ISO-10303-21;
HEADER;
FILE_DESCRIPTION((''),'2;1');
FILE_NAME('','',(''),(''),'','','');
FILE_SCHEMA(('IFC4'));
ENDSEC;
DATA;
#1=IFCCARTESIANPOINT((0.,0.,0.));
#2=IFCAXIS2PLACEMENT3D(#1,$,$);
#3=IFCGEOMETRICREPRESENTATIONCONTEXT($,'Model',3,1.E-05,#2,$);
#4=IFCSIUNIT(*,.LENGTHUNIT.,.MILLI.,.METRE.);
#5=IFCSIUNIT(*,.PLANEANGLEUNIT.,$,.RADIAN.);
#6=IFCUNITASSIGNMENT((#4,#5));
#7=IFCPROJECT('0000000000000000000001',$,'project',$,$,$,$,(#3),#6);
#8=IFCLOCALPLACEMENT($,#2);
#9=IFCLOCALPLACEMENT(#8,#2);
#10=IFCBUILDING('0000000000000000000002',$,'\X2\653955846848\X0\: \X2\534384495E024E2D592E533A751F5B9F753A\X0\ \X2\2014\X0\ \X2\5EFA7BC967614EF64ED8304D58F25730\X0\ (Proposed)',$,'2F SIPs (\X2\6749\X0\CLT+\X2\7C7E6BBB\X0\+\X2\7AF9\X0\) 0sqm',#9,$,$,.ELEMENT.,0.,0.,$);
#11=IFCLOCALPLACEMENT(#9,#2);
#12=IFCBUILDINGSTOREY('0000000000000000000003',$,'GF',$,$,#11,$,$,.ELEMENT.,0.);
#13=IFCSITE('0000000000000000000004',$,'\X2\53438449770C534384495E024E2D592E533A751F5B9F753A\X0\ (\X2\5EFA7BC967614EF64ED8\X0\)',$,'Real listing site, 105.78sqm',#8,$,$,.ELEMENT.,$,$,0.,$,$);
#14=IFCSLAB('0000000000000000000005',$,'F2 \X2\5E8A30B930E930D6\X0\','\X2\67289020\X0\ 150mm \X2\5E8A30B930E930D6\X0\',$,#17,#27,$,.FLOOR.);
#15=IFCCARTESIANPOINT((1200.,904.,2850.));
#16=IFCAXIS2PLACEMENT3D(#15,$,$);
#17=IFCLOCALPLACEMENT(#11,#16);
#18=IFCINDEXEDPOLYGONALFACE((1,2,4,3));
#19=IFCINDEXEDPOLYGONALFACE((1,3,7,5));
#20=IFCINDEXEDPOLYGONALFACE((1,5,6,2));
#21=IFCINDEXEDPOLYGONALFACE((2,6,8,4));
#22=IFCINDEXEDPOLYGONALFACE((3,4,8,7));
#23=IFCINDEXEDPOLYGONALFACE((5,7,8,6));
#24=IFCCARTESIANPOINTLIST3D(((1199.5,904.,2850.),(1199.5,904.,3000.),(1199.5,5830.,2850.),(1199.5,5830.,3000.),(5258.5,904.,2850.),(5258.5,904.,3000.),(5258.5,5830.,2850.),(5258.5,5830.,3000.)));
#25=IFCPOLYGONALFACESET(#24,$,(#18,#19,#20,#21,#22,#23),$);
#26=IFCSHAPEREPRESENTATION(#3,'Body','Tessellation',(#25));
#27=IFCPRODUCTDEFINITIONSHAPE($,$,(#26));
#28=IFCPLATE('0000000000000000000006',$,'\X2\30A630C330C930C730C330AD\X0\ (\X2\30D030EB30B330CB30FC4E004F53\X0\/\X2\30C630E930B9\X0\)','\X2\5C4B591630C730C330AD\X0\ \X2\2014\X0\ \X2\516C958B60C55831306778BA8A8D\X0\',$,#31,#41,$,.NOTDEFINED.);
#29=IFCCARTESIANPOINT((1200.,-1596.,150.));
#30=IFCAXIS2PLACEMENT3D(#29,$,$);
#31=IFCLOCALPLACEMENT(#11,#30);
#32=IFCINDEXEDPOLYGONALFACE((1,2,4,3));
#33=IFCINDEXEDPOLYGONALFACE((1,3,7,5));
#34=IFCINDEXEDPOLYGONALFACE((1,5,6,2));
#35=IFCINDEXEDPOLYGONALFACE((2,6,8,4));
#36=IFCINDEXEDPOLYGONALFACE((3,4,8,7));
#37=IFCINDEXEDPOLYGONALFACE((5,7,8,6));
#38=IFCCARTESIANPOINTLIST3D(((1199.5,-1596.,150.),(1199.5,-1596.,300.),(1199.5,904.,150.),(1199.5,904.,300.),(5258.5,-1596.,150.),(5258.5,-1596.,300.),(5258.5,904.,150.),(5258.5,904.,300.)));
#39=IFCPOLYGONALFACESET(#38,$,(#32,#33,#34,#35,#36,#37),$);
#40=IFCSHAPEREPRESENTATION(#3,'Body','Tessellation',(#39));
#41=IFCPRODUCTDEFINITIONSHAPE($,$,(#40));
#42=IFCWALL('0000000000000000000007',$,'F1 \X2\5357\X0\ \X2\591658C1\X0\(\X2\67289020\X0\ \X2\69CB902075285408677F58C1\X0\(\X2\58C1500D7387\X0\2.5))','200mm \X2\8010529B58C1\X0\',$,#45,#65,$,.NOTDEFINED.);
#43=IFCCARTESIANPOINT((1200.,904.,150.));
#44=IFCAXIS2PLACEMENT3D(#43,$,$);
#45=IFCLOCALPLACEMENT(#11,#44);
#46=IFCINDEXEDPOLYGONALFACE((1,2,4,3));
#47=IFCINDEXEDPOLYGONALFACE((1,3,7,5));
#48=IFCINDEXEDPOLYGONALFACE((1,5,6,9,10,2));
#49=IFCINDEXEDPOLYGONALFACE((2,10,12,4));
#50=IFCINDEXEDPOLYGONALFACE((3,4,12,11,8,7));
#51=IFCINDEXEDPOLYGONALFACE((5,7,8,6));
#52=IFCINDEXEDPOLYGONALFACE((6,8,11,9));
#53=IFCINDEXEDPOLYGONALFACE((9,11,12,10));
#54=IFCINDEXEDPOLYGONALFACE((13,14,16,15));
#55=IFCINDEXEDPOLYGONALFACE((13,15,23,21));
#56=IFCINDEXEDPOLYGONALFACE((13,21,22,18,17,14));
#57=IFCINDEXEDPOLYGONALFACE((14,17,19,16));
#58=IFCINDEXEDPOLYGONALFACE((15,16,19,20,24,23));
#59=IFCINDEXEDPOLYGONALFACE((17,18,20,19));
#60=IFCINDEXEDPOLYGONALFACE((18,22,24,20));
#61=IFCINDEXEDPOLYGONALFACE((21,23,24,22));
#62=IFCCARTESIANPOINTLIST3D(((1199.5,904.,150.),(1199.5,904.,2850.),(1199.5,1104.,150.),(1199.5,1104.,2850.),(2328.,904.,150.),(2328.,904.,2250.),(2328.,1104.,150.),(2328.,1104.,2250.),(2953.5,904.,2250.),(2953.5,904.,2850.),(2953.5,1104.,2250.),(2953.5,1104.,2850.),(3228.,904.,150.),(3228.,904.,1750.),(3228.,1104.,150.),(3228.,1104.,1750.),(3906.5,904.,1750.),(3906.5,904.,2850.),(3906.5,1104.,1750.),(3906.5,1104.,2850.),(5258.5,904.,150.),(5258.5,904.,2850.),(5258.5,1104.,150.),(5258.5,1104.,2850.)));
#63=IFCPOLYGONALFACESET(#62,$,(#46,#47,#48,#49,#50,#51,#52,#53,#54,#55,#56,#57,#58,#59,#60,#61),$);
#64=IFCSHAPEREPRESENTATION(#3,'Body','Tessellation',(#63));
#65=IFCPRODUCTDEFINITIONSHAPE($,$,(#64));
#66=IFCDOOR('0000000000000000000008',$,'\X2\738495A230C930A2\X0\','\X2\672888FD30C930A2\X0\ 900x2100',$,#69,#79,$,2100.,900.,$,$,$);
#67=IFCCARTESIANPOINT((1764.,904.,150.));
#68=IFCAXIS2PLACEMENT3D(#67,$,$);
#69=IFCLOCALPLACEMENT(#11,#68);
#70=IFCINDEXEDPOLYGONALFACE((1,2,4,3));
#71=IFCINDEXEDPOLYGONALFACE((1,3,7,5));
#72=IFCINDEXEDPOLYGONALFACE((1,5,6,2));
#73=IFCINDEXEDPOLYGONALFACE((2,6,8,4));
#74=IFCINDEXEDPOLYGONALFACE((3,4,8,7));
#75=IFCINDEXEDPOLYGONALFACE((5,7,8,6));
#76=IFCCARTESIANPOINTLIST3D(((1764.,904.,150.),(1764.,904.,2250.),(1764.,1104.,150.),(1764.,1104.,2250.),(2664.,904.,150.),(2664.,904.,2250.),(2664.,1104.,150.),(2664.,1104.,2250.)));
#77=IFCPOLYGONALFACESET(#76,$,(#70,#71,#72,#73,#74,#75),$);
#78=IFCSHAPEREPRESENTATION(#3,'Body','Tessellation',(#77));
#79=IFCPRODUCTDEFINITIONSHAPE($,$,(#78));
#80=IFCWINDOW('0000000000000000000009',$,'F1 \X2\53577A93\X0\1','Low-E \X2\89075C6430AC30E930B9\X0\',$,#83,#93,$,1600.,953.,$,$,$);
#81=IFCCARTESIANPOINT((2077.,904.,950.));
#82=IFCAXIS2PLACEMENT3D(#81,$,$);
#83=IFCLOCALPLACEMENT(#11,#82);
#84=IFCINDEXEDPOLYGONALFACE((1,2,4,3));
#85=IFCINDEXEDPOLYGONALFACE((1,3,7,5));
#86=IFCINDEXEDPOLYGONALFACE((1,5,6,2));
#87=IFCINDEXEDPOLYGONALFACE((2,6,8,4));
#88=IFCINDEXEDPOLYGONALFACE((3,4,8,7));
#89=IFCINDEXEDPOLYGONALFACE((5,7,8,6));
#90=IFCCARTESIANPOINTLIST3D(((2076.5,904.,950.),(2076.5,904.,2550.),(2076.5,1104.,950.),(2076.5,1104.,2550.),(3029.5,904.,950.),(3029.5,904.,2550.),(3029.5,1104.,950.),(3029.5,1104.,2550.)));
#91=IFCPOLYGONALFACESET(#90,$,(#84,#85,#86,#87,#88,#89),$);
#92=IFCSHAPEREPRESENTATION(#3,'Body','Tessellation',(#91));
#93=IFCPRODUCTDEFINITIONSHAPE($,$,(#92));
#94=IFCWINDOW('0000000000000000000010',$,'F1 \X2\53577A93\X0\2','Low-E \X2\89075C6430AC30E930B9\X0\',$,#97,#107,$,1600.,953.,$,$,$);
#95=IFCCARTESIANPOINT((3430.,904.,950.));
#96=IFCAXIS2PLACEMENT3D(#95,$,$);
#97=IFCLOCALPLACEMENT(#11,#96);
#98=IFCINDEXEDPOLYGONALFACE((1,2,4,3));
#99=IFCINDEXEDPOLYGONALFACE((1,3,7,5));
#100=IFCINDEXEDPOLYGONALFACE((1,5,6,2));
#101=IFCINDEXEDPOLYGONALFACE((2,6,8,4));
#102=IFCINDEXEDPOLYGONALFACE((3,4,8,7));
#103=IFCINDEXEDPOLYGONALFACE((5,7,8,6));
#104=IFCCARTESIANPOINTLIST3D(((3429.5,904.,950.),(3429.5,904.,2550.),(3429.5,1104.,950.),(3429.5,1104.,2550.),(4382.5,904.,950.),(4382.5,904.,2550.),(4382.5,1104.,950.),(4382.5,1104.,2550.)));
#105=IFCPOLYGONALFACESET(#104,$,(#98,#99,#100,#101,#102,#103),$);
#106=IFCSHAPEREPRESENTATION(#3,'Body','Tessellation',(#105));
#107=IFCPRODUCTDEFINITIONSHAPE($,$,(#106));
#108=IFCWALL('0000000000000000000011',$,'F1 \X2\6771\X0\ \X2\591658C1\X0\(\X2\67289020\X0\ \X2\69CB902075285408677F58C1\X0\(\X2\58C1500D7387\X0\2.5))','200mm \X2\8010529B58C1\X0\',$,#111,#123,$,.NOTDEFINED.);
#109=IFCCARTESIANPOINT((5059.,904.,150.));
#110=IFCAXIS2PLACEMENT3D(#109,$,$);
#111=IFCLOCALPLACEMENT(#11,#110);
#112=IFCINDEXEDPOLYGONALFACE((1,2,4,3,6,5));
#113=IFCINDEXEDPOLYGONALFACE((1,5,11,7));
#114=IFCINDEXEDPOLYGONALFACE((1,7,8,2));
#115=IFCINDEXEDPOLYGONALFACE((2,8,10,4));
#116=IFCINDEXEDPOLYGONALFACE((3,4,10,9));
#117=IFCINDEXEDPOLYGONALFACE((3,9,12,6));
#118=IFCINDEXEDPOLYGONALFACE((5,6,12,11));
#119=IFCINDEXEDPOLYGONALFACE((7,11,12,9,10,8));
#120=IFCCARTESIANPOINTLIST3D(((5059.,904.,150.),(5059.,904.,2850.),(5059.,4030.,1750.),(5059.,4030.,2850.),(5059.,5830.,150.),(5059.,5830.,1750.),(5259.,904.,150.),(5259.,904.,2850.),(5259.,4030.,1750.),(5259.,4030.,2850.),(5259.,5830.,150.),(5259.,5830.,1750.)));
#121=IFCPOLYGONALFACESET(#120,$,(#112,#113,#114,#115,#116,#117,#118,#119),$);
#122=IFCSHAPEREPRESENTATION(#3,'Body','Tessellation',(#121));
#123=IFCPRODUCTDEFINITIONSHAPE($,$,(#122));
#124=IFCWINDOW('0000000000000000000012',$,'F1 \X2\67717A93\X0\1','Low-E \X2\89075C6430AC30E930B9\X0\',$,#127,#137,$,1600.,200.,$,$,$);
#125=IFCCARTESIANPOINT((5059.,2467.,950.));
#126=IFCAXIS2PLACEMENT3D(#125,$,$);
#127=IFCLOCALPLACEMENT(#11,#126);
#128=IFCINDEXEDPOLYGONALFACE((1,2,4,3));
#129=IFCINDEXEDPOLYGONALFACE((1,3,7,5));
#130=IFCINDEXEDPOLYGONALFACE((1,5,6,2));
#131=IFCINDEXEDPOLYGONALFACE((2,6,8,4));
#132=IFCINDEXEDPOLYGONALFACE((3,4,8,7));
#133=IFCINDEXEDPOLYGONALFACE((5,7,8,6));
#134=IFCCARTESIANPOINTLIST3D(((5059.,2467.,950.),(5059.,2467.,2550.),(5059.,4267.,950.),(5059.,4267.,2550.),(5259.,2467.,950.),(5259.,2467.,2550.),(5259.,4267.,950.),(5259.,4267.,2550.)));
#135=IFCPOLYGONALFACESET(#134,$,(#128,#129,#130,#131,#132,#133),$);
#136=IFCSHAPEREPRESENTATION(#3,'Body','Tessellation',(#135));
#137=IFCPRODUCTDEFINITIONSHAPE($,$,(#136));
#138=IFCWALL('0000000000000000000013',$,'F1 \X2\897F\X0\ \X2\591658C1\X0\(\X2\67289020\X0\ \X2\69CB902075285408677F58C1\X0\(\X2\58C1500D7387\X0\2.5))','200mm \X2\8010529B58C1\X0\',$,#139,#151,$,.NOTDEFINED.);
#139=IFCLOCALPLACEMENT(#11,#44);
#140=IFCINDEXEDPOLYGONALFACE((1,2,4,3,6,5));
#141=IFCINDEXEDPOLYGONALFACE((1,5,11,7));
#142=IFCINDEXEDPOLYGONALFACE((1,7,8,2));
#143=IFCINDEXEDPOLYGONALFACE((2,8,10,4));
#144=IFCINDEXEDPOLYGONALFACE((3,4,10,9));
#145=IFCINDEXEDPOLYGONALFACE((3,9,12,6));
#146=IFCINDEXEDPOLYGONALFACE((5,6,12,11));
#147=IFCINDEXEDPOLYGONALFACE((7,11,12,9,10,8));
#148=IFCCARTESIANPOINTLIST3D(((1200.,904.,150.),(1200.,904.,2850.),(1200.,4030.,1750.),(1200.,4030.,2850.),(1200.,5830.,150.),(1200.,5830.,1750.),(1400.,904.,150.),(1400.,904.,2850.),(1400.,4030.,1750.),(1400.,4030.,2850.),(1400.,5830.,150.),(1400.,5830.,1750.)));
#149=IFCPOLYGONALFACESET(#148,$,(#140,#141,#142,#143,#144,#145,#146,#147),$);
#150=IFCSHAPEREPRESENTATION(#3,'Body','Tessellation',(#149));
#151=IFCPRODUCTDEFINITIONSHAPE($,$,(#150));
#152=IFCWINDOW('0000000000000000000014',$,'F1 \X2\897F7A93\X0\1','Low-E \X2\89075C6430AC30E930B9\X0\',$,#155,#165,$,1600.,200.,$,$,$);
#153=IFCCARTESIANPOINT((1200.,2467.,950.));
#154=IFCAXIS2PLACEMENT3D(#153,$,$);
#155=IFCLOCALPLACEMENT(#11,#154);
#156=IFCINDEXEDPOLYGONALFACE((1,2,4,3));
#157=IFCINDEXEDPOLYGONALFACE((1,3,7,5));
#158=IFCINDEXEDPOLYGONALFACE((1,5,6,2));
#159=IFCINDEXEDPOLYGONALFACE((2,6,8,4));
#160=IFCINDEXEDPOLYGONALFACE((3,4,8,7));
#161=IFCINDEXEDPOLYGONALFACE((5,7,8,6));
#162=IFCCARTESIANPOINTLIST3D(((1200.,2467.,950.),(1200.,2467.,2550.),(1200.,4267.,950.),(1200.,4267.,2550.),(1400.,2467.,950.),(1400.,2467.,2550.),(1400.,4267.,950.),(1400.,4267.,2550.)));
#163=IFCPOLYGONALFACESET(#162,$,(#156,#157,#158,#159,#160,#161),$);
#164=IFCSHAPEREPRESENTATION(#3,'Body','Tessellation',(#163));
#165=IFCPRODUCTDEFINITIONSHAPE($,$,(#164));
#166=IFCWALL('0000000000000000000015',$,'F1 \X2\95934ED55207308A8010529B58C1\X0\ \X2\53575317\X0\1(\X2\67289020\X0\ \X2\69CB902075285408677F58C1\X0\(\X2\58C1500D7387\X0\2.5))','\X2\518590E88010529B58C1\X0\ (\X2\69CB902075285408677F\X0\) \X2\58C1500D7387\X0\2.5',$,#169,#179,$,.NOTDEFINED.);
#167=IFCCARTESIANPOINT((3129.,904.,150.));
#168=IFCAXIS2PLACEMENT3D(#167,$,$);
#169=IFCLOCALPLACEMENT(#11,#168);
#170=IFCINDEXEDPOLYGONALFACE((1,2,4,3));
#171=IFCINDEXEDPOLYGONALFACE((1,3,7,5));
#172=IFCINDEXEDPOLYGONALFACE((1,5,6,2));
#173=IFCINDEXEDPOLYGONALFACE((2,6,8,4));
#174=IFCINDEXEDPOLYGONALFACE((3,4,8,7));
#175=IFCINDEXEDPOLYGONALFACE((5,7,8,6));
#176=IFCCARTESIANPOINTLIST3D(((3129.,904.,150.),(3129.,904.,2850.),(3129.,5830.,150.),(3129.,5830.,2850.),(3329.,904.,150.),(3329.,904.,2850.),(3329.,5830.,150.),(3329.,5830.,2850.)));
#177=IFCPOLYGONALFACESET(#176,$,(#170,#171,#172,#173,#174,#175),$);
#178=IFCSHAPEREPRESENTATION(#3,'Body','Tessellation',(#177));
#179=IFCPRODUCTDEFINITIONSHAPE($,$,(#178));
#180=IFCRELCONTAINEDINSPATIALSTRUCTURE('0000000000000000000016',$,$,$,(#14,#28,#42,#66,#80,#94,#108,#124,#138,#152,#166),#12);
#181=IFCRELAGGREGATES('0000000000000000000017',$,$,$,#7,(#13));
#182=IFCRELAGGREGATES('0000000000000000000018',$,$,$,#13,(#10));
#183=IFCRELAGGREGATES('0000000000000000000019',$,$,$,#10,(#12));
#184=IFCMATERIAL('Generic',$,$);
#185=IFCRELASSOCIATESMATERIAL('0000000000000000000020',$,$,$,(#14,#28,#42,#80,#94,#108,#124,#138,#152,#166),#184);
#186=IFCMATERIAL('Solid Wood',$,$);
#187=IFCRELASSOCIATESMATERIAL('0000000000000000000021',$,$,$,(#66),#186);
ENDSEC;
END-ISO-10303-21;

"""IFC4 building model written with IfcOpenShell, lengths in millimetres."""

from ifc_helpers import new_model, si_unit, frame, frame_2d, origin, place, context, project, spatial, rectangle, extrude, material, element, fill, save


model = new_model("IFC4")

# Units and contexts
model_context = context("Model", 3, precision=1e-05, world=origin())
ifc_project = project(units=[si_unit("LENGTHUNIT", "METRE", prefix="MILLI"), si_unit("PLANEANGLEUNIT", "RADIAN")], contexts=[model_context])

# Site, building, storey
site_placement = place(None, origin())
site = spatial("IfcSite", under=ifc_project, at=site_placement, Name="千葉県千葉市中央区生実町 (建築条件付)", ObjectType="Real listing site, 105.78sqm", CompositionType="ELEMENT", RefElevation=0.0)
building_placement = place(site_placement, origin())
building = spatial("IfcBuilding", under=site, at=building_placement, Name="改善案: 千葉市中央区生実町 — 建築条件付き売地 (Proposed)", ObjectType="2F SIPs (杉CLT+籾殻+竹) 0sqm", CompositionType="ELEMENT", ElevationOfRefHeight=0.0, ElevationOfTerrain=0.0)
storey_placement = place(building_placement, origin())
storey = spatial("IfcBuildingStorey", under=building, at=storey_placement, Name="GF", CompositionType="ELEMENT", Elevation=0.0)

# Slab
ifc_material_1 = material(Name="Generic")
slab_1_placement = place(storey_placement, frame((1200.0, 904.0, 2850.0)))
element("IfcSlab", 1, at=slab_1_placement, inside=storey, material=ifc_material_1, Name="F2 床スラブ", Description="木造 150mm 床スラブ", PredefinedType="FLOOR", context=model_context, shape_type="SweptSolid", body=[
    extrude(rectangle(XDim=4059.0, YDim=4926.0, at=frame_2d((2029.0, 2463.0))), frame((1200.0, 904.0, 2850.0)), (0.0, 0.0, 1.0), 150.0),
])

# Plate
plate_placement = place(storey_placement, frame((1200.0, -1596.0, 150.0)))
element("IfcPlate", 2, at=plate_placement, inside=storey, material=ifc_material_1, Name="ウッドデッキ (バルコニー一体/テラス)", Description="屋外デッキ — 公開情報で確認", PredefinedType="NOTDEFINED", context=model_context, shape_type="SweptSolid", body=[
    extrude(rectangle(XDim=4059.0, YDim=2500.0, at=frame_2d((2029.0, 1250.0))), frame((1200.0, -1596.0, 150.0)), (0.0, 0.0, 1.0), 150.0),
])

# Wall, openings, door, windows
wall_1_placement = place(storey_placement, frame((1200.0, 904.0, 150.0)))
wall_1 = element("IfcWall", 3, at=wall_1_placement, inside=storey, material=ifc_material_1, Name="F1 南 外壁(木造 構造用合板壁(壁倍率2.5))", Description="200mm 耐力壁", PredefinedType="NOTDEFINED", context=model_context, shape_type="SweptSolid", body=[
    extrude(rectangle(XDim=4059.0, YDim=200.0, at=frame_2d((2029.0, 100.0))), frame((1200.0, 904.0, 150.0)), (0.0, 0.0, 1.0), 2700.0),
])
opening_1_placement = place(storey_placement, frame((1764.0, 904.0, 150.0)))
opening_1 = element("IfcOpeningElement", 4, at=opening_1_placement, cuts=wall_1, PredefinedType="NOTDEFINED", context=model_context, shape_type="SweptSolid", body=[
    extrude(rectangle(XDim=900.0, YDim=200.0, at=frame_2d((450.0, 100.0))), frame((1764.0, 904.0, 150.0)), (0.0, 0.0, 1.0), 2100.0),
])
opening_2_placement = place(storey_placement, frame((2077.0, 904.0, 950.0)))
opening_2 = element("IfcOpeningElement", 5, at=opening_2_placement, cuts=wall_1, PredefinedType="NOTDEFINED", context=model_context, shape_type="SweptSolid", body=[
    extrude(rectangle(XDim=953.0, YDim=200.0, at=frame_2d((476.0, 100.0))), frame((2077.0, 904.0, 950.0)), (0.0, 0.0, 1.0), 1600.0),
])
opening_3_placement = place(storey_placement, frame((3430.0, 904.0, 950.0)))
opening_3 = element("IfcOpeningElement", 6, at=opening_3_placement, cuts=wall_1, PredefinedType="NOTDEFINED", context=model_context, shape_type="SweptSolid", body=[
    extrude(rectangle(XDim=953.0, YDim=200.0, at=frame_2d((476.0, 100.0))), frame((3430.0, 904.0, 950.0)), (0.0, 0.0, 1.0), 1600.0),
])
ifc_material_2 = material(Name="Solid Wood")
door_placement = place(storey_placement, frame((1764.0, 904.0, 150.0)))
door = element("IfcDoor", 7, at=door_placement, inside=storey, material=ifc_material_2, Name="玄関ドア", Description="木製ドア 900x2100", OverallHeight=2100.0, OverallWidth=900.0, context=model_context, shape_type="SweptSolid", body=[
    extrude(rectangle(XDim=900.0, YDim=200.0, at=frame_2d((450.0, 100.0))), frame((1764.0, 904.0, 150.0)), (0.0, 0.0, 1.0), 2100.0),
])
fill(opening_1, door)
window_1_placement = place(storey_placement, frame((2077.0, 904.0, 950.0)))
window_1 = element("IfcWindow", 8, at=window_1_placement, inside=storey, material=ifc_material_1, Name="F1 南窓1", Description="Low-E 複層ガラス", OverallHeight=1600.0, OverallWidth=953.0, context=model_context, shape_type="SweptSolid", body=[
    extrude(rectangle(XDim=953.0, YDim=200.0, at=frame_2d((476.0, 100.0))), frame((2077.0, 904.0, 950.0)), (0.0, 0.0, 1.0), 1600.0),
])
fill(opening_2, window_1)
window_2_placement = place(storey_placement, frame((3430.0, 904.0, 950.0)))
window_2 = element("IfcWindow", 9, at=window_2_placement, inside=storey, material=ifc_material_1, Name="F1 南窓2", Description="Low-E 複層ガラス", OverallHeight=1600.0, OverallWidth=953.0, context=model_context, shape_type="SweptSolid", body=[
    extrude(rectangle(XDim=953.0, YDim=200.0, at=frame_2d((476.0, 100.0))), frame((3430.0, 904.0, 950.0)), (0.0, 0.0, 1.0), 1600.0),
])
fill(opening_3, window_2)

# Walls, openings, windows
wall_2_placement = place(storey_placement, frame((5059.0, 904.0, 150.0)))
wall_2 = element("IfcWall", 10, at=wall_2_placement, inside=storey, material=ifc_material_1, Name="F1 東 外壁(木造 構造用合板壁(壁倍率2.5))", Description="200mm 耐力壁", PredefinedType="NOTDEFINED", context=model_context, shape_type="SweptSolid", body=[
    extrude(rectangle(XDim=200.0, YDim=4926.0, at=frame_2d((100.0, 2463.0))), frame((5059.0, 904.0, 150.0)), (0.0, 0.0, 1.0), 2700.0),
])
opening_4_placement = place(storey_placement, frame((5059.0, 2467.0, 950.0)))
opening_4 = element("IfcOpeningElement", 11, at=opening_4_placement, cuts=wall_2, PredefinedType="NOTDEFINED", context=model_context, shape_type="SweptSolid", body=[
    extrude(rectangle(XDim=200.0, YDim=1800.0, at=frame_2d((100.0, 900.0))), frame((5059.0, 2467.0, 950.0)), (0.0, 0.0, 1.0), 1600.0),
])
window_3_placement = place(storey_placement, frame((5059.0, 2467.0, 950.0)))
window_3 = element("IfcWindow", 12, at=window_3_placement, inside=storey, material=ifc_material_1, Name="F1 東窓1", Description="Low-E 複層ガラス", OverallHeight=1600.0, OverallWidth=200.0, context=model_context, shape_type="SweptSolid", body=[
    extrude(rectangle(XDim=200.0, YDim=1800.0, at=frame_2d((100.0, 900.0))), frame((5059.0, 2467.0, 950.0)), (0.0, 0.0, 1.0), 1600.0),
])
fill(opening_4, window_3)
wall_3_placement = place(storey_placement, frame((1200.0, 904.0, 150.0)))
wall_3 = element("IfcWall", 13, at=wall_3_placement, inside=storey, material=ifc_material_1, Name="F1 西 外壁(木造 構造用合板壁(壁倍率2.5))", Description="200mm 耐力壁", PredefinedType="NOTDEFINED", context=model_context, shape_type="SweptSolid", body=[
    extrude(rectangle(XDim=200.0, YDim=4926.0, at=frame_2d((100.0, 2463.0))), frame((1200.0, 904.0, 150.0)), (0.0, 0.0, 1.0), 2700.0),
])
opening_5_placement = place(storey_placement, frame((1200.0, 2467.0, 950.0)))
opening_5 = element("IfcOpeningElement", 14, at=opening_5_placement, cuts=wall_3, PredefinedType="NOTDEFINED", context=model_context, shape_type="SweptSolid", body=[
    extrude(rectangle(XDim=200.0, YDim=1800.0, at=frame_2d((100.0, 900.0))), frame((1200.0, 2467.0, 950.0)), (0.0, 0.0, 1.0), 1600.0),
])
window_4_placement = place(storey_placement, frame((1200.0, 2467.0, 950.0)))
window_4 = element("IfcWindow", 15, at=window_4_placement, inside=storey, material=ifc_material_1, Name="F1 西窓1", Description="Low-E 複層ガラス", OverallHeight=1600.0, OverallWidth=200.0, context=model_context, shape_type="SweptSolid", body=[
    extrude(rectangle(XDim=200.0, YDim=1800.0, at=frame_2d((100.0, 900.0))), frame((1200.0, 2467.0, 950.0)), (0.0, 0.0, 1.0), 1600.0),
])
fill(opening_5, window_4)

# Wall
wall_4_placement = place(storey_placement, frame((3129.0, 904.0, 150.0)))
element("IfcWall", 16, at=wall_4_placement, inside=storey, material=ifc_material_1, Name="F1 間仕切り耐力壁 南北1(木造 構造用合板壁(壁倍率2.5))", Description="内部耐力壁 (構造用合板) 壁倍率2.5", PredefinedType="NOTDEFINED", context=model_context, shape_type="SweptSolid", body=[
    extrude(rectangle(XDim=200.0, YDim=4926.0, at=frame_2d((100.0, 2463.0))), frame((3129.0, 904.0, 150.0)), (0.0, 0.0, 1.0), 2700.0),
])

save(model, "model.ifc")
